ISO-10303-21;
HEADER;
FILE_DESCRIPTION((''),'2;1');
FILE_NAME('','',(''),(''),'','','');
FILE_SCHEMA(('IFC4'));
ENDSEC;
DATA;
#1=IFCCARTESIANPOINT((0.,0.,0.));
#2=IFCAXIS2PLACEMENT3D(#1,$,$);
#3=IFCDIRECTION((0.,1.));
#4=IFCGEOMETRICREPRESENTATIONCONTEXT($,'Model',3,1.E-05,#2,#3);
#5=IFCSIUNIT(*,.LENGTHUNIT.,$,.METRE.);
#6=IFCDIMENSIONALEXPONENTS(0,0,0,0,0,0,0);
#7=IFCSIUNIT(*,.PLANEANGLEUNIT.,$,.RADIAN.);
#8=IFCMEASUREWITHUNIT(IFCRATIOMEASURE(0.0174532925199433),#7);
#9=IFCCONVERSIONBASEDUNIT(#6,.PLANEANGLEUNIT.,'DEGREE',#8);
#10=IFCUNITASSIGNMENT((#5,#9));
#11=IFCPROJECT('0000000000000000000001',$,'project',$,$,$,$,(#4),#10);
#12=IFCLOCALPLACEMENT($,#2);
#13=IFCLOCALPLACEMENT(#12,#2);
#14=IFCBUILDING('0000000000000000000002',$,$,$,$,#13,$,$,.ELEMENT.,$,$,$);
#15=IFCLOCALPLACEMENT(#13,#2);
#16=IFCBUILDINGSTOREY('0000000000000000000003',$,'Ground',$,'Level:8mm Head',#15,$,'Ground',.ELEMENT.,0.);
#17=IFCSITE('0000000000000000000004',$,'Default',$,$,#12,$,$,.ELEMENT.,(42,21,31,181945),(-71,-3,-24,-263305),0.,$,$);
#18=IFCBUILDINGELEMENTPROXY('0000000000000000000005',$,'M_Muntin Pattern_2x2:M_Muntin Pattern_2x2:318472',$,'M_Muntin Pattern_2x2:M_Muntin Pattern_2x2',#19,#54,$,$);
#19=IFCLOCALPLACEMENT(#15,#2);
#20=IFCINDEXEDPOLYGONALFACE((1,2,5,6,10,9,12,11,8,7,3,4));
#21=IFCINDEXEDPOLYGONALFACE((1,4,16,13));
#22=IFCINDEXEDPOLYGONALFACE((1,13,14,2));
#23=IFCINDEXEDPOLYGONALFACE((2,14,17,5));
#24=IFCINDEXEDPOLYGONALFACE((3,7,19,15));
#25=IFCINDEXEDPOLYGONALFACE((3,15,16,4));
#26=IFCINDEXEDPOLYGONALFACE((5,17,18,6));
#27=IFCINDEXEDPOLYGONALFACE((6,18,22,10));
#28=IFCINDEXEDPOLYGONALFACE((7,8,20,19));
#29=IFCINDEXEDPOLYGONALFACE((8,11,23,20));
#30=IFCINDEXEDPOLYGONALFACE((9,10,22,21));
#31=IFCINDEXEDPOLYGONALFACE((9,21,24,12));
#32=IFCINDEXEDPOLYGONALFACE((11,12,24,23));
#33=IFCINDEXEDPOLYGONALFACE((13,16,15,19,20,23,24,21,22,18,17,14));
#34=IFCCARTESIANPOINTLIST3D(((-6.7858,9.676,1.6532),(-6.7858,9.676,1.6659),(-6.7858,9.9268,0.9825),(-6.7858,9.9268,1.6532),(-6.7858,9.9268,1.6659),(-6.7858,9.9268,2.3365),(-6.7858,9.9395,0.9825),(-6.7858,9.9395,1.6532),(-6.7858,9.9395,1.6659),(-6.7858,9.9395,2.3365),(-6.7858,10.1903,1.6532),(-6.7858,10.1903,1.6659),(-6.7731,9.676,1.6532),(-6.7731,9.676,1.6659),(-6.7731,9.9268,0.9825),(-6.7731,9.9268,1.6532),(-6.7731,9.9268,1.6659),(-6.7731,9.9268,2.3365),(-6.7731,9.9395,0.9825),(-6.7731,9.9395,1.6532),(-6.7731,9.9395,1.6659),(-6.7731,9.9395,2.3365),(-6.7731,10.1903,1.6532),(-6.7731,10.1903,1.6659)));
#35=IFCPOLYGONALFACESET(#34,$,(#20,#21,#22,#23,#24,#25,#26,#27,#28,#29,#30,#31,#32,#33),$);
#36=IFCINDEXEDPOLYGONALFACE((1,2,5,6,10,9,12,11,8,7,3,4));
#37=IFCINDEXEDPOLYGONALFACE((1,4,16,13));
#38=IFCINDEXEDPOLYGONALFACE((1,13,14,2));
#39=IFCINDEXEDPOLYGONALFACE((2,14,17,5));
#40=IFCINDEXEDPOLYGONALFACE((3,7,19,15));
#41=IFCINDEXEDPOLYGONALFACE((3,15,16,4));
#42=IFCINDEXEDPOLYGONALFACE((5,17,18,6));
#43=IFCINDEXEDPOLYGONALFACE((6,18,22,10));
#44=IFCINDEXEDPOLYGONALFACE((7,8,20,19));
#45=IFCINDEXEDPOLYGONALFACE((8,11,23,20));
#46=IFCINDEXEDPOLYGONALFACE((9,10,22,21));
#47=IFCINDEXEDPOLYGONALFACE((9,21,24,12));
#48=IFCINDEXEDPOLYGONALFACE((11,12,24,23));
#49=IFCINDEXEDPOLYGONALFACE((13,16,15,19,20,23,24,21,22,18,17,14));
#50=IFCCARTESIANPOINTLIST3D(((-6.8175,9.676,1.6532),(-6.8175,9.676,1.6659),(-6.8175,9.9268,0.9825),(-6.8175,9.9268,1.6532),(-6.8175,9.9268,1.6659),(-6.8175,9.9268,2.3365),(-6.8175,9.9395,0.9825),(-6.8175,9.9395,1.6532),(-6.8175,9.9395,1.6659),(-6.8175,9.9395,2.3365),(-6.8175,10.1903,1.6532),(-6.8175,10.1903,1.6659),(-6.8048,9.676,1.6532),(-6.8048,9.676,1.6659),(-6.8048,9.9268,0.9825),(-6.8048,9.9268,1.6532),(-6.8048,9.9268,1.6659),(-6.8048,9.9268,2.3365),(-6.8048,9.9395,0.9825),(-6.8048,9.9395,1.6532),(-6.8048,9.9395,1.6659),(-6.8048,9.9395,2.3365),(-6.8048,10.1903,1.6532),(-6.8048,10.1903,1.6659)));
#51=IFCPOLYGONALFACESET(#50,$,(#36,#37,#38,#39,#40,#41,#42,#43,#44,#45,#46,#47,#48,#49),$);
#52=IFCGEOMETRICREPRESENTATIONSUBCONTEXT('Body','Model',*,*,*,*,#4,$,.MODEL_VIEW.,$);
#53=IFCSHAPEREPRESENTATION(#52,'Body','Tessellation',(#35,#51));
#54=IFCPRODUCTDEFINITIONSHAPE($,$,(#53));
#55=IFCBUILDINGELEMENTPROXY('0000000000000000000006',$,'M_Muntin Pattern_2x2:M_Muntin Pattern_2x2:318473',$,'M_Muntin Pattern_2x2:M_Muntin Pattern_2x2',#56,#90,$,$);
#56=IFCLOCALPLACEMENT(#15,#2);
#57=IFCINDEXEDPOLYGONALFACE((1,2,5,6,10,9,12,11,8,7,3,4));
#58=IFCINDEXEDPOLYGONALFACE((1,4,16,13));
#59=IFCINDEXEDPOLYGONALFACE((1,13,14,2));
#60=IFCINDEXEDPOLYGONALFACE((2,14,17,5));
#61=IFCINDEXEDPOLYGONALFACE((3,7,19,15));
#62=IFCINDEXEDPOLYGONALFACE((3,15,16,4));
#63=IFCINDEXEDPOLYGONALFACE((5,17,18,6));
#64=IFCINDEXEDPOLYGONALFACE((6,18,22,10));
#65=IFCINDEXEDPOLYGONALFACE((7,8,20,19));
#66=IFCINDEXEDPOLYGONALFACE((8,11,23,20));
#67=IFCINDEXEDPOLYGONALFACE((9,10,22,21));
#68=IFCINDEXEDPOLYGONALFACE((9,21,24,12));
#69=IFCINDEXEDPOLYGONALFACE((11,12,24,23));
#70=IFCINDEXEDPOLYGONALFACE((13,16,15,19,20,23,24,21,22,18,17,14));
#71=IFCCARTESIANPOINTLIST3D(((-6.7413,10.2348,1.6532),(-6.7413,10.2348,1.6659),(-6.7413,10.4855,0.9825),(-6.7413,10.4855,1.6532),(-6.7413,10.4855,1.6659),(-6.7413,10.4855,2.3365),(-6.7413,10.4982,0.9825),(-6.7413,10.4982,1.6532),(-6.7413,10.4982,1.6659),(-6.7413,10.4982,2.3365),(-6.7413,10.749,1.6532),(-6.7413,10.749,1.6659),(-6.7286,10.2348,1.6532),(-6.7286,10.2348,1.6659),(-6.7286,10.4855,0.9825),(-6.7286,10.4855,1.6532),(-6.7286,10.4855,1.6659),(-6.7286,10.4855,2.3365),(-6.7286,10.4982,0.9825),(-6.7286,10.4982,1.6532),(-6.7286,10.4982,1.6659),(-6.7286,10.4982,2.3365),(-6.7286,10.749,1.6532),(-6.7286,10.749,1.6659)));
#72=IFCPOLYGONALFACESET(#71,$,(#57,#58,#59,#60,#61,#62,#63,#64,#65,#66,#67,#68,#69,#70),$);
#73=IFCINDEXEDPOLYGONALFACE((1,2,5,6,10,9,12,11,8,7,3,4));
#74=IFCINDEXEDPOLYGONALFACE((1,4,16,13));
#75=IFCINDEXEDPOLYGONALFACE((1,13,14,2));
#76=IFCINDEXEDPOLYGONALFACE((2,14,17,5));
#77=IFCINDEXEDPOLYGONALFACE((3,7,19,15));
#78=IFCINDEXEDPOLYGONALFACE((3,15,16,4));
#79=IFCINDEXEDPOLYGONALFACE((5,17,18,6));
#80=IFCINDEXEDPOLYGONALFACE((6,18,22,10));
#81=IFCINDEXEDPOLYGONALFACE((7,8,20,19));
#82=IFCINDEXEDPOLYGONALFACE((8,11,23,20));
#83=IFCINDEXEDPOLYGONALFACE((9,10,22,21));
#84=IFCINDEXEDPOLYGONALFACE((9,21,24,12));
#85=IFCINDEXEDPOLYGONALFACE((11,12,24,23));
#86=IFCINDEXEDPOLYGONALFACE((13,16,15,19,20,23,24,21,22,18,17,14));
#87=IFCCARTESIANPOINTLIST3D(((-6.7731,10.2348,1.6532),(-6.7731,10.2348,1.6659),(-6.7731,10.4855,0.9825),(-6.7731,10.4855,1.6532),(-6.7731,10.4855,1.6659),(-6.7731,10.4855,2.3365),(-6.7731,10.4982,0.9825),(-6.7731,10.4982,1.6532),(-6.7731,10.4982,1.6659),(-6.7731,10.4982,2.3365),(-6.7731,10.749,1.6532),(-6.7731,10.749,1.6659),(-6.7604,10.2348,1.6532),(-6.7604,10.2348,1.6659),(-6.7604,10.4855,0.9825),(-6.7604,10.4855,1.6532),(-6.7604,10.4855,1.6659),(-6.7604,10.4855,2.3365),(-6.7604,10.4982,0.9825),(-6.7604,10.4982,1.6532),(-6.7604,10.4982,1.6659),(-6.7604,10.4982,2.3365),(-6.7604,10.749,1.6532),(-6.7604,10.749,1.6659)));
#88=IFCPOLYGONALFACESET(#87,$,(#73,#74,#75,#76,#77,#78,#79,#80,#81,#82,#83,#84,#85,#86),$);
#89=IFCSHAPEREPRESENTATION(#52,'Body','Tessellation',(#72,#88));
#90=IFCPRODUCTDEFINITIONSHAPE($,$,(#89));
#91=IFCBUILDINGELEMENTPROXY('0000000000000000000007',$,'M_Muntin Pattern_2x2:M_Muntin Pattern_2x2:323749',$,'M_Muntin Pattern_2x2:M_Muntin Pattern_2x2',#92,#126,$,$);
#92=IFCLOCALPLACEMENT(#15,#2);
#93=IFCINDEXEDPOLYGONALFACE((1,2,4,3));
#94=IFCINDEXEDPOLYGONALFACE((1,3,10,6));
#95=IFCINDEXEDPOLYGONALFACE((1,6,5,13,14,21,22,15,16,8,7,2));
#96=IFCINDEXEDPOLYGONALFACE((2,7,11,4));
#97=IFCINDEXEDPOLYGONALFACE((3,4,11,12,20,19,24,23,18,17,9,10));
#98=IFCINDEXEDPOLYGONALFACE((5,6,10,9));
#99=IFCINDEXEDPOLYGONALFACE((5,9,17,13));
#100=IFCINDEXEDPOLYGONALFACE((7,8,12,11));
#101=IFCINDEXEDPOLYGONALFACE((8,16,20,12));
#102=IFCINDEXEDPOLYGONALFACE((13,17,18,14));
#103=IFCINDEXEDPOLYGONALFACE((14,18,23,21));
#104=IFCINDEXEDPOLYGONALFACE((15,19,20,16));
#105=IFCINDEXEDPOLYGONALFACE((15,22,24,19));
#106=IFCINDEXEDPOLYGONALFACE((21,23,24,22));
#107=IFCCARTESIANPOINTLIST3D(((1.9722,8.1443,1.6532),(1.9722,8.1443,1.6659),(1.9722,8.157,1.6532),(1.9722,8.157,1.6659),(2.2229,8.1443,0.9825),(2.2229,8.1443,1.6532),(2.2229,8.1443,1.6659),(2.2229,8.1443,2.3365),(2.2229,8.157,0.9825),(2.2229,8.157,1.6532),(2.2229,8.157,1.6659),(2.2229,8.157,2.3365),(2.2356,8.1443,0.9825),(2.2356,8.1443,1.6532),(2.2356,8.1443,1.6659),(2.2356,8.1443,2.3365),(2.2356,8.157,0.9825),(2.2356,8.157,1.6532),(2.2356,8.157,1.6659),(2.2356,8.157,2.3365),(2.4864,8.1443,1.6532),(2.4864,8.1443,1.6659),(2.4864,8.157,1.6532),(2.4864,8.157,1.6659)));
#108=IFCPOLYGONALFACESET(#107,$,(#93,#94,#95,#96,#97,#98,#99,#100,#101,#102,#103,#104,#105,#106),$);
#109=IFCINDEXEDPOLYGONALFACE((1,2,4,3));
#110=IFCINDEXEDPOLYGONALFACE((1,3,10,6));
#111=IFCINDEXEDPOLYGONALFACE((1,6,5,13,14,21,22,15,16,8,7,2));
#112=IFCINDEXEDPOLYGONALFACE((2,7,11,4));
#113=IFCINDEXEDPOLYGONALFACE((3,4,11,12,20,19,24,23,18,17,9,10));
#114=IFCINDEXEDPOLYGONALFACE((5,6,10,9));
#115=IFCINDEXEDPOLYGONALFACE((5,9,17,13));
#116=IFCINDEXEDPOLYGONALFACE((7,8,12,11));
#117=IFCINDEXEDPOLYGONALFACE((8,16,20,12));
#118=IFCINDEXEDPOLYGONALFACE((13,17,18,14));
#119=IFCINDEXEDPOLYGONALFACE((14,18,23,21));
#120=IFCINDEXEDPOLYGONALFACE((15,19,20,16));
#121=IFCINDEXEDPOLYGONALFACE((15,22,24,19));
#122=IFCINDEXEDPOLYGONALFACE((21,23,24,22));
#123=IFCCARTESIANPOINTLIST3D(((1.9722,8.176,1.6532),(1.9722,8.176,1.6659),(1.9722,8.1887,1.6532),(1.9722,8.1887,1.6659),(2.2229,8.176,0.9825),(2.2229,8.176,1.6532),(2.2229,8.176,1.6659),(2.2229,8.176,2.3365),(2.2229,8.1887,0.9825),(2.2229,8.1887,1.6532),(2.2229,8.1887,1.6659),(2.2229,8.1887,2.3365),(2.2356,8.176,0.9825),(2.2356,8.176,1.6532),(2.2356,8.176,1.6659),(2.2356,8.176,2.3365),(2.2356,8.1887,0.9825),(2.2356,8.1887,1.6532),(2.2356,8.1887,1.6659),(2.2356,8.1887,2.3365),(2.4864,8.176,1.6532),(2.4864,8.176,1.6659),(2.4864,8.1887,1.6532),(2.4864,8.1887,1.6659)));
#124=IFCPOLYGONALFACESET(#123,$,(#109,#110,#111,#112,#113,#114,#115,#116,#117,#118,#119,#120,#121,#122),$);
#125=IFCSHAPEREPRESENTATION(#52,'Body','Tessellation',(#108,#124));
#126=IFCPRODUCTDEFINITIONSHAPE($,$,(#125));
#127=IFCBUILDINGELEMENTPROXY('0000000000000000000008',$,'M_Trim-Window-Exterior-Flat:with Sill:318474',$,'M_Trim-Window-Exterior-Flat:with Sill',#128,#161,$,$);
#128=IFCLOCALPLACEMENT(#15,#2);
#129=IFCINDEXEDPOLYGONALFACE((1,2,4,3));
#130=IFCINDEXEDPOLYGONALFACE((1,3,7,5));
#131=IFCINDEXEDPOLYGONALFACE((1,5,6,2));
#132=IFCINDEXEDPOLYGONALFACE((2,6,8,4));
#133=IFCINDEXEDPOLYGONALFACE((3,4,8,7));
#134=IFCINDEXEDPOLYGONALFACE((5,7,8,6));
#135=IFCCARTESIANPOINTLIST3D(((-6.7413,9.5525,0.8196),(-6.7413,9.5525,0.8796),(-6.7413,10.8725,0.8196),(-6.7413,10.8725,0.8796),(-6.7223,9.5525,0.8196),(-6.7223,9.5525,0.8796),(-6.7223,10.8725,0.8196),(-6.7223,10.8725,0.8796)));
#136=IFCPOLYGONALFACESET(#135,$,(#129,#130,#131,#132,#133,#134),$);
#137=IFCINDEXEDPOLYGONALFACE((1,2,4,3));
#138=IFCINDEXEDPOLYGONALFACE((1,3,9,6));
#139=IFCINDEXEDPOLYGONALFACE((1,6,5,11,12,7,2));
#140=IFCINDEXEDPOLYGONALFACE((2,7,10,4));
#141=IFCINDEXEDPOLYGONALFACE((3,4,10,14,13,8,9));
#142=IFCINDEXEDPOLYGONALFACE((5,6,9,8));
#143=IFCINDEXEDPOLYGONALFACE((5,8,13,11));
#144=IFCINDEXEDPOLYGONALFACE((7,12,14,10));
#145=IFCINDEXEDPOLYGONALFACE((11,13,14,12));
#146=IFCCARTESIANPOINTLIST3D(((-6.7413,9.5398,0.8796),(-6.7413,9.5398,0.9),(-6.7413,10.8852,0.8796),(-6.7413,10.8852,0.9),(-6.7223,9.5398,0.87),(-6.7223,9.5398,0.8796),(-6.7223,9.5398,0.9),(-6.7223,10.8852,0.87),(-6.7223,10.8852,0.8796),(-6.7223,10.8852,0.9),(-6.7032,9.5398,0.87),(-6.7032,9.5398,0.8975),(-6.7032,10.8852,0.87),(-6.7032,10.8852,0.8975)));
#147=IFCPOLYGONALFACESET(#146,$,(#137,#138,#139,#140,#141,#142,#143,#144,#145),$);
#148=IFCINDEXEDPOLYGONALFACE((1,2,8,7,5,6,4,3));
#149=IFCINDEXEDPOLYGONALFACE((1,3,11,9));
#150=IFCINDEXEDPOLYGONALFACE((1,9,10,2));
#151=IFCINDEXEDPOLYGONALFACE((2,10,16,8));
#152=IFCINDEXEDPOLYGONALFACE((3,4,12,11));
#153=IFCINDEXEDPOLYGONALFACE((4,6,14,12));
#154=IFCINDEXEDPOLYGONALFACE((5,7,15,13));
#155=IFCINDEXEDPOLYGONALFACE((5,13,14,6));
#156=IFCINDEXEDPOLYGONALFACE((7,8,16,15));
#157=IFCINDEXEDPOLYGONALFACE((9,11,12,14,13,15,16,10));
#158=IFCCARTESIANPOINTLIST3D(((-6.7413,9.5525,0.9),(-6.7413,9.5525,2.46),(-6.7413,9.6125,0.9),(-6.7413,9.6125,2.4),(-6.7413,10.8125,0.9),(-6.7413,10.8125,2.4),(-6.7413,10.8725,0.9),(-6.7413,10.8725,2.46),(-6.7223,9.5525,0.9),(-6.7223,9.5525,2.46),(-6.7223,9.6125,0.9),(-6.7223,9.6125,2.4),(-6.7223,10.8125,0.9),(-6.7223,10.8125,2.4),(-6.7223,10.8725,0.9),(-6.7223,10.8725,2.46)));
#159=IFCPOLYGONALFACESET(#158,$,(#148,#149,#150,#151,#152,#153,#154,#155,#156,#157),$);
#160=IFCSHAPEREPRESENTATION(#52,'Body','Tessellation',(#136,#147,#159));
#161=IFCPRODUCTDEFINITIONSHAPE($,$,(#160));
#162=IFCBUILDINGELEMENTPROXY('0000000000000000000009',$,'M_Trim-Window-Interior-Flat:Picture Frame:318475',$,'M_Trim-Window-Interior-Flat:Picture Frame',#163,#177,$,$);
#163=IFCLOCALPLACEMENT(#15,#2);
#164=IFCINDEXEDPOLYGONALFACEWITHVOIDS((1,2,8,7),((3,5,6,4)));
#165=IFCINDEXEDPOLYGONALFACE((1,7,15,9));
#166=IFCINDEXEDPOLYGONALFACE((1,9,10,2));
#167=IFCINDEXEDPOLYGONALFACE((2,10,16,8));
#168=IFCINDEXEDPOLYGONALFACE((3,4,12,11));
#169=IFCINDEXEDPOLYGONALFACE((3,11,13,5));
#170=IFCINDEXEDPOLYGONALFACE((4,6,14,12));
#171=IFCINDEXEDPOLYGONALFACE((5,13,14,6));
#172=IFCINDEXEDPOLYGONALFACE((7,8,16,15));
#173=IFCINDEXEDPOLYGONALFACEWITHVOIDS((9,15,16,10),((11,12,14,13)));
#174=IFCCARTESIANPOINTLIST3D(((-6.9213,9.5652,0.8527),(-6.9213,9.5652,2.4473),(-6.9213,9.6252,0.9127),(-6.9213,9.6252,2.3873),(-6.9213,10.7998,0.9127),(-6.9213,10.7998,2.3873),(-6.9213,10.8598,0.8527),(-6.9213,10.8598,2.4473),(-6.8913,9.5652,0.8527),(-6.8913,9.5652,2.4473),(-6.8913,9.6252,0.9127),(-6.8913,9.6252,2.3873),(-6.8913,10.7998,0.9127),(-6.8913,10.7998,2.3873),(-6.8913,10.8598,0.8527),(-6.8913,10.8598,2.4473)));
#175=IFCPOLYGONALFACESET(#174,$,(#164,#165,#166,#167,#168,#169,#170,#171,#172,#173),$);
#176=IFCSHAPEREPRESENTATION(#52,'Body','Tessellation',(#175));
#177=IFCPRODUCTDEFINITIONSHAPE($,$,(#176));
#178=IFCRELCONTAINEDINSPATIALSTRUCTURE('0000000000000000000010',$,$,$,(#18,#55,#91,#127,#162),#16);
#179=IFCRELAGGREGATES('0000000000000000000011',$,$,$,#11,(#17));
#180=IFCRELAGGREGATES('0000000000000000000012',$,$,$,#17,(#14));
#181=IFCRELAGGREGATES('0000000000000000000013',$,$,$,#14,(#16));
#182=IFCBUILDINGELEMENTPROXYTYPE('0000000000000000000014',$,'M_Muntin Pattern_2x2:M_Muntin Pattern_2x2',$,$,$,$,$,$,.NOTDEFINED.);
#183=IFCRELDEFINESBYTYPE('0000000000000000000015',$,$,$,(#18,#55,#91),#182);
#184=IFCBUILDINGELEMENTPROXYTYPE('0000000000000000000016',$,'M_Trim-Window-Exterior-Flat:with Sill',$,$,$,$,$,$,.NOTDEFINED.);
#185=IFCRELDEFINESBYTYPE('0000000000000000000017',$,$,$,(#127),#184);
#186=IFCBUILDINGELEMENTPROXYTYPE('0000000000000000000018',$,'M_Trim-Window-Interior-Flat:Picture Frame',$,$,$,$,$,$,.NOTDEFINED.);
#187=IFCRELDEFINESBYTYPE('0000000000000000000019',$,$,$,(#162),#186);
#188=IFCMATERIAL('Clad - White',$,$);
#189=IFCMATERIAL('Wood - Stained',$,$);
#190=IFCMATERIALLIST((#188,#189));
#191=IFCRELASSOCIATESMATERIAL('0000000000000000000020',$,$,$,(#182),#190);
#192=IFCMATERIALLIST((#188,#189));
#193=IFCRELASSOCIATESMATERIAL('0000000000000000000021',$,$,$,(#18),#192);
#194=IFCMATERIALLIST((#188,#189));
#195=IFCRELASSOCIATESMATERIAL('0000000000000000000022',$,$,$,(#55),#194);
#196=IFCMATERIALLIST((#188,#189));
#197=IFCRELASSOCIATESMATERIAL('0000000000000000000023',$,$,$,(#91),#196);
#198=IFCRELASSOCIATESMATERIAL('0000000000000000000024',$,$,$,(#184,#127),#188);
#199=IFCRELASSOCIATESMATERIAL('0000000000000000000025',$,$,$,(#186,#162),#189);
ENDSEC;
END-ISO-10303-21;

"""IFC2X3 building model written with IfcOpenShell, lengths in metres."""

from ifc_helpers import new_model, entity, si_unit, converted_unit, direction, frame, frame_2d, origin, place, context, subcontext, project, spatial, polyline, rectangle, outline, extrude, source, transform, mapped, material, material_list, type_object, type_shapes, element, save


model = new_model("IFC2X3")

# Units and contexts
model_context = context("Model", 3, precision=1e-05, world=origin(), true_north=direction((0.0, 1.0)))
body_context = subcontext(model_context, "Body", "Model", "MODEL_VIEW")
ifc_project = project(units=[si_unit("LENGTHUNIT", "METRE"), converted_unit("PLANEANGLEUNIT", "DEGREE", entity("IfcRatioMeasure", 0.0174532925199433), si_unit("PLANEANGLEUNIT", "RADIAN"), dimensions=[0, 0, 0, 0, 0, 0, 0])], contexts=[model_context])

# Site, building, storey
site_placement = place(None, origin())
site = spatial("IfcSite", under=ifc_project, at=site_placement, Name="Default", CompositionType="ELEMENT", RefLatitude=(42, 21, 31, 181945), RefLongitude=(-71, -3, -24, -263305), RefElevation=0.0)
building_placement = place(site_placement, origin())
building = spatial("IfcBuilding", under=site, at=building_placement, CompositionType="ELEMENT")
storey_placement = place(building_placement, origin())
storey = spatial("IfcBuildingStorey", under=building, at=storey_placement, Name="Ground", ObjectType="Level:8mm Head", LongName="Ground", CompositionType="ELEMENT", Elevation=0.0)

# Building element proxies
ifc_material_1 = material(Name="Clad - White")
ifc_material_2 = material(Name="Wood - Stained")
ifc_material_list_1 = material_list([ifc_material_1, ifc_material_2])
ifc_material_list_2 = material_list([ifc_material_1, ifc_material_2])
building_element_proxy_type_1 = type_object("IfcBuildingElementProxyType", Name="M_Muntin Pattern_2x2:M_Muntin Pattern_2x2", PredefinedType="NOTDEFINED", material=ifc_material_list_2)
shared_shape_1 = source(origin(), body_context, "Body", "SweptSolid", [
    extrude(outline(polyline([(0.0064, -0.0064), (0.677, -0.0064), (0.677, 0.0063), (0.0064, 0.0063), (0.0064, 0.2571), (-0.0063, 0.2571), (-0.0063, 0.0063), (-0.677, 0.0063), (-0.677, -0.0064), (-0.0063, -0.0064), (-0.0063, -0.2571), (0.0064, -0.2571), (0.0064, -0.0064)])), frame((0.0, 0.0095, 0.677), z_axis=(0.0, 1.0, 0.0), x_axis=(0.0, 0.0, 1.0)), (0.0, 0.0, 1.0), 0.0127),
    extrude(outline(polyline([(0.0064, -0.0064), (0.677, -0.0064), (0.677, 0.0063), (0.0064, 0.0063), (0.0064, 0.2571), (-0.0063, 0.2571), (-0.0063, 0.0063), (-0.677, 0.0063), (-0.677, -0.0064), (-0.0063, -0.0064), (-0.0063, -0.2571), (0.0064, -0.2571), (0.0064, -0.0064)])), frame((0.0, -0.0222, 0.677), z_axis=(0.0, 1.0, 0.0), x_axis=(0.0, 0.0, 1.0)), (0.0, 0.0, 1.0), 0.0127),
])
type_shapes(building_element_proxy_type_1, [shared_shape_1])
proxy_1_placement = place(storey_placement, frame((-6.7953, 9.9332, 0.9825), z_axis=(0.0, 0.0, 1.0), x_axis=(0.0, -1.0, 0.0)))
element("IfcBuildingElementProxy", 1, at=proxy_1_placement, inside=storey, type_object=building_element_proxy_type_1, material=ifc_material_list_1, Name="M_Muntin Pattern_2x2:M_Muntin Pattern_2x2:318472", ObjectType="M_Muntin Pattern_2x2:M_Muntin Pattern_2x2", context=body_context, shape_type="MappedRepresentation", body=[
    mapped(shared_shape_1, transform((0.0, 0.0, 0.0), scale=1.0)),
])
ifc_material_list_3 = material_list([ifc_material_1, ifc_material_2])
proxy_2_placement = place(storey_placement, frame((-6.7509, 10.4919, 0.9825), z_axis=(0.0, 0.0, 1.0), x_axis=(0.0, -1.0, 0.0)))
element("IfcBuildingElementProxy", 2, at=proxy_2_placement, inside=storey, type_object=building_element_proxy_type_1, material=ifc_material_list_3, Name="M_Muntin Pattern_2x2:M_Muntin Pattern_2x2:318473", ObjectType="M_Muntin Pattern_2x2:M_Muntin Pattern_2x2", context=body_context, shape_type="MappedRepresentation", body=[
    mapped(shared_shape_1, transform((0.0, 0.0, 0.0), scale=1.0)),
])
ifc_material_list_4 = material_list([ifc_material_1, ifc_material_2])
proxy_3_placement = place(storey_placement, frame((2.2293, 8.1665, 0.9825), z_axis=(0.0, 0.0, 1.0), x_axis=(-1.0, 0.0, 0.0)))
element("IfcBuildingElementProxy", 3, at=proxy_3_placement, inside=storey, type_object=building_element_proxy_type_1, material=ifc_material_list_4, Name="M_Muntin Pattern_2x2:M_Muntin Pattern_2x2:323749", ObjectType="M_Muntin Pattern_2x2:M_Muntin Pattern_2x2", context=body_context, shape_type="MappedRepresentation", body=[
    mapped(shared_shape_1, transform((0.0, 0.0, 0.0), scale=1.0)),
])
building_element_proxy_type_2 = type_object("IfcBuildingElementProxyType", Name="M_Trim-Window-Exterior-Flat:with Sill", PredefinedType="NOTDEFINED", material=ifc_material_1)
shared_shape_2 = source(origin(), body_context, "Body", "SweptSolid", [
    extrude(rectangle(XDim=1.32, YDim=0.06, at=frame_2d((0.0, 0.0), x_axis=(1.0, 0.0))), frame((0.0, -1.5504, 0.0), z_axis=(0.0, 0.0, 1.0), x_axis=(-1.0, 0.0, 0.0)), (0.0, 0.0, 1.0), 0.0191),
    extrude(outline(polyline([(-0.019, -0.0152), (0.0, -0.0152), (0.0, -0.0057), (0.019, -0.0057), (0.019, 0.0148), (0.0, 0.0148), (-0.019, 0.0123), (-0.019, -0.0152)])), frame((-0.6727, -1.5148, 0.019), z_axis=(1.0, 0.0, 0.0), x_axis=(0.0, 0.0, -1.0)), (0.0, 0.0, 1.0), 1.3454),
    extrude(outline(polyline([(-0.795, -0.66), (0.765, -0.66), (0.765, -0.6), (-0.735, -0.6), (-0.735, 0.6), (0.765, 0.6), (0.765, 0.66), (-0.795, 0.66), (-0.795, -0.66)])), frame((0.0, -0.735, 0.0), z_axis=(0.0, 0.0, 1.0), x_axis=(0.0, -1.0, 0.0)), (0.0, 0.0, 1.0), 0.0191),
])
type_shapes(building_element_proxy_type_2, [shared_shape_2])
proxy_4_placement = place(storey_placement, frame((-6.7413, 10.2125, 2.4), z_axis=(1.0, 0.0, 0.0), x_axis=(0.0, 1.0, 0.0)))
element("IfcBuildingElementProxy", 4, at=proxy_4_placement, inside=storey, type_object=building_element_proxy_type_2, material=ifc_material_1, Name="M_Trim-Window-Exterior-Flat:with Sill:318474", ObjectType="M_Trim-Window-Exterior-Flat:with Sill", context=body_context, shape_type="MappedRepresentation", body=[
    mapped(shared_shape_2, transform((0.0, 0.0, 0.0), scale=1.0)),
])
building_element_proxy_type_3 = type_object("IfcBuildingElementProxyType", Name="M_Trim-Window-Interior-Flat:Picture Frame", PredefinedType="NOTDEFINED", material=ifc_material_2)
shared_shape_3 = source(origin(), body_context, "Body", "SweptSolid", [
    extrude(outline(polyline([(-0.6473, -0.7973), (0.6473, -0.7973), (0.6473, 0.7973), (-0.6473, 0.7973), (-0.6473, -0.7973)]), holes=[polyline([(-0.5873, -0.7373), (-0.5873, 0.7373), (0.5873, 0.7373), (0.5873, -0.7373), (-0.5873, -0.7373)])]), frame((0.0, -0.75, 0.0), z_axis=(0.0, 0.0, 1.0), x_axis=(-1.0, 0.0, 0.0)), (0.0, 0.0, 1.0), 0.03),
])
type_shapes(building_element_proxy_type_3, [shared_shape_3])
for number, where, z_axis, x_axis, name in (
    (5, (-6.8913, 10.2125, 2.4), (-1.0, 0.0, 0.0), (0.0, -1.0, 0.0), "M_Trim-Window-Interior-Flat:Picture Frame:318475"),
):
    element("IfcBuildingElementProxy", number, at=place(storey_placement, frame(where, z_axis=z_axis, x_axis=x_axis)), inside=storey, type_object=building_element_proxy_type_3, material=ifc_material_2, Name=name, ObjectType="M_Trim-Window-Interior-Flat:Picture Frame", context=body_context, shape_type="MappedRepresentation", body=[
        mapped(shared_shape_3, transform((0.0, 0.0, 0.0), scale=1.0)),
    ])

save(model, "model.ifc")
